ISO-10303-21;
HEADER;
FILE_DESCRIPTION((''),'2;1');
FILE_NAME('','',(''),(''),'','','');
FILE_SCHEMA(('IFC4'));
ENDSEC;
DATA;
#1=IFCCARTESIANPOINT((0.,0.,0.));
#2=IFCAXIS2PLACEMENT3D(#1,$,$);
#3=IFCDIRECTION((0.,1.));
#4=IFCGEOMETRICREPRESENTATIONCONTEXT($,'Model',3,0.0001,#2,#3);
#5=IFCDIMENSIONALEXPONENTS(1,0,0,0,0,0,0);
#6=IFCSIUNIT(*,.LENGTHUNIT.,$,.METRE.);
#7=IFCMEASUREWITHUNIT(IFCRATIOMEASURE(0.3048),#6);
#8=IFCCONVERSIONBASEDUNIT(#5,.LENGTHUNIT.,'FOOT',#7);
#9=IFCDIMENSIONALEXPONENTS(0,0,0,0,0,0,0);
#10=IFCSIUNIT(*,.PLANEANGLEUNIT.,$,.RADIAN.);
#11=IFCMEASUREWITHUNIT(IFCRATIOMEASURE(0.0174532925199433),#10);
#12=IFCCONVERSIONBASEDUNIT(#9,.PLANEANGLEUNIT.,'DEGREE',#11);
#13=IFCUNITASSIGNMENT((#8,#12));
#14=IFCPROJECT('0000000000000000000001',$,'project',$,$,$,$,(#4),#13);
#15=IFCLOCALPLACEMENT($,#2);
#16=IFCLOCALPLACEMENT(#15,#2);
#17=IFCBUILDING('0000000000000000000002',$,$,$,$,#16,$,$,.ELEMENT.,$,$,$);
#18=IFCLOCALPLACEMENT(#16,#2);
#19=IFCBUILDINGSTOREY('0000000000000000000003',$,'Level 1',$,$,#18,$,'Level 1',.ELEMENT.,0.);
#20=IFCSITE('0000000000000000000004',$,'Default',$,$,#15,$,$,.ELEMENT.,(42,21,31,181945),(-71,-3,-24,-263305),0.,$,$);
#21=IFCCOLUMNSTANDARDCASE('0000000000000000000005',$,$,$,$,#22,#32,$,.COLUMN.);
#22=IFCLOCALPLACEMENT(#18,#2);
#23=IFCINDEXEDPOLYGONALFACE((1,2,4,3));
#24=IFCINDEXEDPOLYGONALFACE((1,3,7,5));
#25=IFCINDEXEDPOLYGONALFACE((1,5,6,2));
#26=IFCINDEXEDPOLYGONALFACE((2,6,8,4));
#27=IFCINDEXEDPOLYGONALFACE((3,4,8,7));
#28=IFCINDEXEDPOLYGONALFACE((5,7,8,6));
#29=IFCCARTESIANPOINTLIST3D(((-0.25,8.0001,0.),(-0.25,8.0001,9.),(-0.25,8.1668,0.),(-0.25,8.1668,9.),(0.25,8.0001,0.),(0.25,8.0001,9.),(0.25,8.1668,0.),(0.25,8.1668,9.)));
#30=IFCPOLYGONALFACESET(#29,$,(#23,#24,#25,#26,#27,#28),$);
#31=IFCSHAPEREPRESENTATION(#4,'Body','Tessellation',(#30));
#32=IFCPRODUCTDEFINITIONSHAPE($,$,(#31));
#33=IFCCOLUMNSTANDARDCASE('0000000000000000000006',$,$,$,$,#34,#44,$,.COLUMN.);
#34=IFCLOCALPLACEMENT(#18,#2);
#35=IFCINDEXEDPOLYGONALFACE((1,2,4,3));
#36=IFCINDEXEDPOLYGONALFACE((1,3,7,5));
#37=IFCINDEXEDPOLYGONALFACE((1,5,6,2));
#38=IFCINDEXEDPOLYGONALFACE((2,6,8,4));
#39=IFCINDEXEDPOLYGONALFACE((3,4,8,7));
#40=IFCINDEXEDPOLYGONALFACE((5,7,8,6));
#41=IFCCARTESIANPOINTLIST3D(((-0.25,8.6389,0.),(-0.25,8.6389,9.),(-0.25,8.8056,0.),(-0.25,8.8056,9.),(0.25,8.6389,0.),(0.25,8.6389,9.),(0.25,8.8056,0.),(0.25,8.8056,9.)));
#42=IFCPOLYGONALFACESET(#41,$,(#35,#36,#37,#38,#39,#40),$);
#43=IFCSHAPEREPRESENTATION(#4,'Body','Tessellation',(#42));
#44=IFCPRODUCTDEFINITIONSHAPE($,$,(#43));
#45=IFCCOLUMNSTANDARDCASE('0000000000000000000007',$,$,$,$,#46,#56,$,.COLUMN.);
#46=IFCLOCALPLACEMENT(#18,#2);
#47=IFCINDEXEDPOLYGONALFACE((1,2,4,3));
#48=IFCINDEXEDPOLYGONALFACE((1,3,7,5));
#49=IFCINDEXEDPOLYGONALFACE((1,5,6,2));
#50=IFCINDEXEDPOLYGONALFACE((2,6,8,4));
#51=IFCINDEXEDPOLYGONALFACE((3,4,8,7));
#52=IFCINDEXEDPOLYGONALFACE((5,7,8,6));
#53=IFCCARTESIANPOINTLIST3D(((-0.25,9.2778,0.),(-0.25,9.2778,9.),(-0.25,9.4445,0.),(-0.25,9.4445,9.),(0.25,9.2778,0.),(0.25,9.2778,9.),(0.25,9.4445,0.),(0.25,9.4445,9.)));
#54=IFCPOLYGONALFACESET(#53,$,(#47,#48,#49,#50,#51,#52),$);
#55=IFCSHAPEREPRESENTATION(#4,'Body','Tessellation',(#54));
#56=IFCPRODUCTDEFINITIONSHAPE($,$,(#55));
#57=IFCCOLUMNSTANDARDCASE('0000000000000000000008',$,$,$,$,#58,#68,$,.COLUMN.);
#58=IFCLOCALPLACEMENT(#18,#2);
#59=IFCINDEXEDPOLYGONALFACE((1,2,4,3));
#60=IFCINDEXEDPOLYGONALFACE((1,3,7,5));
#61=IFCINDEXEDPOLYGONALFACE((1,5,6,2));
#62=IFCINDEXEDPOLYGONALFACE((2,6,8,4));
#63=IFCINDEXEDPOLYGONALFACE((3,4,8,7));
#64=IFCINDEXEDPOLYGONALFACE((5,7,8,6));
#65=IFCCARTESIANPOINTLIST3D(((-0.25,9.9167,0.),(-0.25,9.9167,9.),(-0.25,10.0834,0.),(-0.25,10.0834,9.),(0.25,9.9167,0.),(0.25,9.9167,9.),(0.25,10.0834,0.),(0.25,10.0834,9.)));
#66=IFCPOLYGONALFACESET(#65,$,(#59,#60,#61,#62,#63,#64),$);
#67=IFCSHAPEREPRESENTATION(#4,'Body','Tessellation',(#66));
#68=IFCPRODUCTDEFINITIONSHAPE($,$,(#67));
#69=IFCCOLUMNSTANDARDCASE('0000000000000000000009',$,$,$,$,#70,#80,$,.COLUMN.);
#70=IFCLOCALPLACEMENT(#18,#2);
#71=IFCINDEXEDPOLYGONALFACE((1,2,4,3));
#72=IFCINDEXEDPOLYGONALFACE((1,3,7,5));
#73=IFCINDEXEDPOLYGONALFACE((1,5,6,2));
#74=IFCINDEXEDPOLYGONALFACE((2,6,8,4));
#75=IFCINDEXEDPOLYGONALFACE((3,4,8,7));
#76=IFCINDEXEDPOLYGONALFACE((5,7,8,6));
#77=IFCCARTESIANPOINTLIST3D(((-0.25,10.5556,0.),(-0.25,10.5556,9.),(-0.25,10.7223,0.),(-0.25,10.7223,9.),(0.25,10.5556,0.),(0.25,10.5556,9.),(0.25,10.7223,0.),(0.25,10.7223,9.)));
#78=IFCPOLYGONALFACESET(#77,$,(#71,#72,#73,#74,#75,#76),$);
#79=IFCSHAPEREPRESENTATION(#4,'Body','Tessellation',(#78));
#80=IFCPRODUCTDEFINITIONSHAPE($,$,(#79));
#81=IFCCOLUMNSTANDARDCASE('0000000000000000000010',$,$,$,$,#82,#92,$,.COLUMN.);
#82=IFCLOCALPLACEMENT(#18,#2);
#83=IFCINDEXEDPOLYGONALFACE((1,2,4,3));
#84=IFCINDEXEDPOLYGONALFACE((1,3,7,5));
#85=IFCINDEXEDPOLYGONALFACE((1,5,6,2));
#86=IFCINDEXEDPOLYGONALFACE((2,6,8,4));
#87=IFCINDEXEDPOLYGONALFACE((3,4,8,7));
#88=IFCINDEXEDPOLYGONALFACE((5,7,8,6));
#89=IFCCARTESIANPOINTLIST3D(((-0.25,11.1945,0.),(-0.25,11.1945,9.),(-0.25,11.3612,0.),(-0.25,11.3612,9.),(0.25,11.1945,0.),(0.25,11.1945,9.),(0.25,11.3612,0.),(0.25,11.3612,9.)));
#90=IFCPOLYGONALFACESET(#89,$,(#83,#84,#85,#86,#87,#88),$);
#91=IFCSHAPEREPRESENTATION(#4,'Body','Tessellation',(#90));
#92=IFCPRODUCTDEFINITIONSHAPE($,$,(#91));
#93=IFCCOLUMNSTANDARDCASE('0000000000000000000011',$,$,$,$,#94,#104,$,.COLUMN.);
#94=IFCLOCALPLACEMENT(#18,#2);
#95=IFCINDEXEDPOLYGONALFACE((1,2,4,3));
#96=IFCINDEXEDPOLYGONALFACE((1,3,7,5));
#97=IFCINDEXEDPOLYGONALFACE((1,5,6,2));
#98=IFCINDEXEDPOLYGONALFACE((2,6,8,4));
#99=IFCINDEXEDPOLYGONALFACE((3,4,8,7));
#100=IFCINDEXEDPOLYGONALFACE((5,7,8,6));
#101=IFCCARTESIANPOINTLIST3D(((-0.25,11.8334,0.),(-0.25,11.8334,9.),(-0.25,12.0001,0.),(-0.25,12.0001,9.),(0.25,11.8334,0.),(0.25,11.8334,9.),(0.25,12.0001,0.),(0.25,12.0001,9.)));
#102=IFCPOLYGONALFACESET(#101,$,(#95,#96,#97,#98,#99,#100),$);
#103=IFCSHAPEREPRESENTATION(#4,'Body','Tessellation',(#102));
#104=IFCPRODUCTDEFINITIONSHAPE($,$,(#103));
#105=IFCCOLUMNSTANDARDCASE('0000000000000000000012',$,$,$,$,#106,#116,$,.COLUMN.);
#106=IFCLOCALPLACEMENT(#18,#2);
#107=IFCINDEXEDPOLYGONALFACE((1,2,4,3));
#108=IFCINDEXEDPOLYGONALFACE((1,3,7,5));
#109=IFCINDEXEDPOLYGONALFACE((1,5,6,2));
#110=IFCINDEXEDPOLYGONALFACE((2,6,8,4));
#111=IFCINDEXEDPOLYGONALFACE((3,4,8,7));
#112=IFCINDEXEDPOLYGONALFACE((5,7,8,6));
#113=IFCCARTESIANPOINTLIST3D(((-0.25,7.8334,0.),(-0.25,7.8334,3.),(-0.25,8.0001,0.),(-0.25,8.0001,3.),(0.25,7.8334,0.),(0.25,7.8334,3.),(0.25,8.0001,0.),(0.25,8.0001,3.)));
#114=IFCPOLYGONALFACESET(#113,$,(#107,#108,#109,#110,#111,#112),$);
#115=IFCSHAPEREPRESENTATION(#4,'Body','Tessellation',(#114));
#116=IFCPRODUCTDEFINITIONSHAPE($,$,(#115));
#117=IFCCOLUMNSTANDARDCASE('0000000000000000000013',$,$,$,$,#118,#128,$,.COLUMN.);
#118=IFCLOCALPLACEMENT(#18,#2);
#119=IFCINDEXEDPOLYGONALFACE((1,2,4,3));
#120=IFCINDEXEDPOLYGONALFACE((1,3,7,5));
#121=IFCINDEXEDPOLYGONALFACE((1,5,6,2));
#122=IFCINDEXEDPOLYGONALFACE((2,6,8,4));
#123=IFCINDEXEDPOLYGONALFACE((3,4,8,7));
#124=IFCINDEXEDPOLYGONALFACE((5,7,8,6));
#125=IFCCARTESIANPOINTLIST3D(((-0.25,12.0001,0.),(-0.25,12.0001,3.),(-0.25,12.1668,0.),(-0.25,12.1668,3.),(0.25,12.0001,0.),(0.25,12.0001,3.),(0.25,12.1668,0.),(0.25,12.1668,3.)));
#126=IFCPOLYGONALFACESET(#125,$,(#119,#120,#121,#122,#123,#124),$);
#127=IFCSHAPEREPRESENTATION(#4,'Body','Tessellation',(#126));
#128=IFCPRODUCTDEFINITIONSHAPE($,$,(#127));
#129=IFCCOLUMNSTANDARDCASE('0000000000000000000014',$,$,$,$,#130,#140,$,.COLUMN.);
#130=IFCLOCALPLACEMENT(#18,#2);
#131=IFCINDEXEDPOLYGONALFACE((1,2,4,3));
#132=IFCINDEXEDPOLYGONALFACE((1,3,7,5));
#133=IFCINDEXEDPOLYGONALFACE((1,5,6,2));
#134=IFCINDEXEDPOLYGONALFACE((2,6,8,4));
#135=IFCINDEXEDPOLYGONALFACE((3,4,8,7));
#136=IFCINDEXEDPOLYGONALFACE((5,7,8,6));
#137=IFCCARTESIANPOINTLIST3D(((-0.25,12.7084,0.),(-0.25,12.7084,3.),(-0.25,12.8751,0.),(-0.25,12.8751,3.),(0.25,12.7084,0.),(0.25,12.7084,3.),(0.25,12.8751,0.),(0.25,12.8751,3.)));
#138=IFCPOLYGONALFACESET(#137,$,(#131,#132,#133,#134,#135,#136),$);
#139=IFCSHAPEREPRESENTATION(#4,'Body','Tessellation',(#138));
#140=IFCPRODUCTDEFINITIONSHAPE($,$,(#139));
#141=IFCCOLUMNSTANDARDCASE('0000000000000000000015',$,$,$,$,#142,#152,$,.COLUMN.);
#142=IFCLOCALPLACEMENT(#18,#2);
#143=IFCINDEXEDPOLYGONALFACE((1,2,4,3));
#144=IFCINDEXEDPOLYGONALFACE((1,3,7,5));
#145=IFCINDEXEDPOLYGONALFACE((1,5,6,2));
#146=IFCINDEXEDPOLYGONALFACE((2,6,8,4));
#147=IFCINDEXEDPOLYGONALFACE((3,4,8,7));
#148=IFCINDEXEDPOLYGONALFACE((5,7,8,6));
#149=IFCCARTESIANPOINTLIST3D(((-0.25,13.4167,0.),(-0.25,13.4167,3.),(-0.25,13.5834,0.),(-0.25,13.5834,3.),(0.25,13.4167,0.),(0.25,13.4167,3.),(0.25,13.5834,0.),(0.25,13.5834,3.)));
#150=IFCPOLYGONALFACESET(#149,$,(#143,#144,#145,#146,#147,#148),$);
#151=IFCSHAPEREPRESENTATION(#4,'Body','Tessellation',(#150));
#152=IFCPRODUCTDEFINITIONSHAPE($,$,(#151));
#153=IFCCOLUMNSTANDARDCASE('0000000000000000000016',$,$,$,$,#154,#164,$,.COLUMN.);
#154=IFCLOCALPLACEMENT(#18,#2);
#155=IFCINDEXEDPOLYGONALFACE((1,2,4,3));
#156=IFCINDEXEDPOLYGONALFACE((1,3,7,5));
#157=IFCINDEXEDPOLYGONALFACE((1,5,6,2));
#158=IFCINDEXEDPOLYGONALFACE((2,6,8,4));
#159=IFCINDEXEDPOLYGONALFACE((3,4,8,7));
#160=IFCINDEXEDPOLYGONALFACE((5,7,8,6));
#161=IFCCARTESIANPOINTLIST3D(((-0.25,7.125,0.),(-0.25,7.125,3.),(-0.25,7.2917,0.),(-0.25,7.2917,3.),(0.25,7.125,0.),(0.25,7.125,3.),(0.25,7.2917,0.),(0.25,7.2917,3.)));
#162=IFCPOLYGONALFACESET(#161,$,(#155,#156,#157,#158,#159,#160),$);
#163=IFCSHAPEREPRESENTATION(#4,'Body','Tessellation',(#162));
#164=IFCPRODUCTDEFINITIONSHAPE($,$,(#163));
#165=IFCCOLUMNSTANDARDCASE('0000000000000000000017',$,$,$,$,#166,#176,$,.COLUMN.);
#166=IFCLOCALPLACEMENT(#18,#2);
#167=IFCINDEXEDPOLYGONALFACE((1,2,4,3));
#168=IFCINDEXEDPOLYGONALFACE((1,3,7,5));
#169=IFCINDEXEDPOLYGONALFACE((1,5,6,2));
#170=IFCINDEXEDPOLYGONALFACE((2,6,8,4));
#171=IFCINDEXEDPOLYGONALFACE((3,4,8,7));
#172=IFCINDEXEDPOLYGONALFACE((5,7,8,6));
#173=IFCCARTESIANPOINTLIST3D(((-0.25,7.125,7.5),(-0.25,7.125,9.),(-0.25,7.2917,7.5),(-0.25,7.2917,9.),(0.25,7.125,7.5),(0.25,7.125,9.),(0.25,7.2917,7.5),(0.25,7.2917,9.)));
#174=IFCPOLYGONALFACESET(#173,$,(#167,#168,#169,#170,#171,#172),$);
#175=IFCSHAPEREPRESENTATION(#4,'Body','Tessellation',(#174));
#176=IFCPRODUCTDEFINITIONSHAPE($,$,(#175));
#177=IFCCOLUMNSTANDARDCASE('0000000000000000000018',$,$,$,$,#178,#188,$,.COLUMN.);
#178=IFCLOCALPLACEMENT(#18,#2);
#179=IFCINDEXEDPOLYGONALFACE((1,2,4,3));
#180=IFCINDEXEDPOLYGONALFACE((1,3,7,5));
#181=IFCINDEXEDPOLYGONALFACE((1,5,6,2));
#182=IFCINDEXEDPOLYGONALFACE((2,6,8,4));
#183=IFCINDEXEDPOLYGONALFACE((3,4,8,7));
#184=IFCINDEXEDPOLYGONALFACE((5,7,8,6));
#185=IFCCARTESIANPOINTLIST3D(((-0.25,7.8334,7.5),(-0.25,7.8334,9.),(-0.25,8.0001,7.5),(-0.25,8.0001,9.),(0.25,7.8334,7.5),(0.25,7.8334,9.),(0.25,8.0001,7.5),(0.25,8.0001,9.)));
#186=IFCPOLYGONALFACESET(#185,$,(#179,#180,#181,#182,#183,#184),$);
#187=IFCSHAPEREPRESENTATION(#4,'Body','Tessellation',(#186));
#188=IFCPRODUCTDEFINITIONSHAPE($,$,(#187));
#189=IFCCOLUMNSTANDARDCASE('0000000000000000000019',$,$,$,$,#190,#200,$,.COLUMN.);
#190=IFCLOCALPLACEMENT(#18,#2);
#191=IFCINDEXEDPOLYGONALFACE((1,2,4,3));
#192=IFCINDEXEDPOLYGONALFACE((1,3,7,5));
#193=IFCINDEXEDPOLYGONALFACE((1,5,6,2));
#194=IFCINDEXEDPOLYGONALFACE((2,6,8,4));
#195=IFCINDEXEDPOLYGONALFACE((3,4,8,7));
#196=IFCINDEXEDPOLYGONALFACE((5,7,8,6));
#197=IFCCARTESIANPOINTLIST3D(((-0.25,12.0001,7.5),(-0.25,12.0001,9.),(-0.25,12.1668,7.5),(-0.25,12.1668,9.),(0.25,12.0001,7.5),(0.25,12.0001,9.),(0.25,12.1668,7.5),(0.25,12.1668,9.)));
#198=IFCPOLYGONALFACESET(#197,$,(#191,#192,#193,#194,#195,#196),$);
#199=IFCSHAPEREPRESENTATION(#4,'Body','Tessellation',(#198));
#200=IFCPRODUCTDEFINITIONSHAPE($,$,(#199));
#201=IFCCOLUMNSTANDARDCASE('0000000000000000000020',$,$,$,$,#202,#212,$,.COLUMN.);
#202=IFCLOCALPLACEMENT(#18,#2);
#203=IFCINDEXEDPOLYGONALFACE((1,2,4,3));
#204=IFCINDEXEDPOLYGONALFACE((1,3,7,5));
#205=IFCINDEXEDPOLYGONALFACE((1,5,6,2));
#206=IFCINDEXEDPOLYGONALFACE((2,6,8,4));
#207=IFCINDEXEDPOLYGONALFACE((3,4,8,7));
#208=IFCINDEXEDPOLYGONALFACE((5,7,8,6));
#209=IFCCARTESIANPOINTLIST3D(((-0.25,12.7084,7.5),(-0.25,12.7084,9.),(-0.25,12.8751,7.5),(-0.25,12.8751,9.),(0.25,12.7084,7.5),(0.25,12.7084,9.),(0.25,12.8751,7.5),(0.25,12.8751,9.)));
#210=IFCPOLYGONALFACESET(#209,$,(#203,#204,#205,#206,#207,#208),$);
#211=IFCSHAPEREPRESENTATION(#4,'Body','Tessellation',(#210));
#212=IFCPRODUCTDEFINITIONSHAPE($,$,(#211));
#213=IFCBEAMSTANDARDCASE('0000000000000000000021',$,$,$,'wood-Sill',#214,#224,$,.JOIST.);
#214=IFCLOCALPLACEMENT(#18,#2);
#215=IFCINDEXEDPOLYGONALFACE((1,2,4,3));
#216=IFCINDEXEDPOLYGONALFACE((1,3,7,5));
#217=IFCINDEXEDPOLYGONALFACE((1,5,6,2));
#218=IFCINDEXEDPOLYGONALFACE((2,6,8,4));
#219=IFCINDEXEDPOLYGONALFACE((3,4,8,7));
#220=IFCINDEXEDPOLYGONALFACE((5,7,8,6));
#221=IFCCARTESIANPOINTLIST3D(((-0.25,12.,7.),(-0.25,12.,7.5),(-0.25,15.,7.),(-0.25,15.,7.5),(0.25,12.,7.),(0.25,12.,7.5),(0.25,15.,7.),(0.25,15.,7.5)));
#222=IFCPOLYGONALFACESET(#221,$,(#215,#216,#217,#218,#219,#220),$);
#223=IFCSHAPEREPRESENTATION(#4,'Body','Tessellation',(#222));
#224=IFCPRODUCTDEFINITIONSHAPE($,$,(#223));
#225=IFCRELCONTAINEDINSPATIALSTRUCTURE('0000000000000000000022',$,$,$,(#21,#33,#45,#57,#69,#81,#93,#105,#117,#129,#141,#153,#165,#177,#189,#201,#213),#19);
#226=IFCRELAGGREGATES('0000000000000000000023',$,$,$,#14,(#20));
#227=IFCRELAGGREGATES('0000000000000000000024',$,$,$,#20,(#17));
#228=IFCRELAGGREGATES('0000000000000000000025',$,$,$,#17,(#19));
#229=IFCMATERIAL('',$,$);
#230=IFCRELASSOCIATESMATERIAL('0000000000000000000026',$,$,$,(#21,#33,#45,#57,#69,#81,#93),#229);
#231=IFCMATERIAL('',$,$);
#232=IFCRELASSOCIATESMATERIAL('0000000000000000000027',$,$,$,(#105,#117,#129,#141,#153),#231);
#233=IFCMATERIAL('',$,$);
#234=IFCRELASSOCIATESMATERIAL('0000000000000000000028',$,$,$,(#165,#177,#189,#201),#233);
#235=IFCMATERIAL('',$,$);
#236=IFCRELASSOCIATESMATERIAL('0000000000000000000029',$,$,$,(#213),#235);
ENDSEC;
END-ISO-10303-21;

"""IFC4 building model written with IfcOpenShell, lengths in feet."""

from ifc_helpers import new_model, entity, si_unit, converted_unit, direction, frame, origin, place, context, project, spatial, rectangle, extrude, material, element, save


model = new_model("IFC4")

# Units and contexts
model_context = context("Model", 3, precision=0.0001, world=origin(), true_north=direction((0.0, 1.0)))
ifc_project = project(units=[converted_unit("LENGTHUNIT", "FOOT", entity("IfcRatioMeasure", 0.3048), si_unit("LENGTHUNIT", "METRE"), dimensions=[1, 0, 0, 0, 0, 0, 0]), converted_unit("PLANEANGLEUNIT", "DEGREE", entity("IfcRatioMeasure", 0.0174532925199433), si_unit("PLANEANGLEUNIT", "RADIAN"), dimensions=[0, 0, 0, 0, 0, 0, 0])], contexts=[model_context])

# Site, building, storey
site_placement = place(None, origin())
site = spatial("IfcSite", under=ifc_project, at=site_placement, Name="Default", CompositionType="ELEMENT", RefLatitude=(42, 21, 31, 181945), RefLongitude=(-71, -3, -24, -263305), RefElevation=0.0)
building_placement = place(site_placement, origin())
building = spatial("IfcBuilding", under=site, at=building_placement, CompositionType="ELEMENT")
storey_placement = place(building_placement, origin())
storey = spatial("IfcBuildingStorey", under=building, at=storey_placement, Name="Level 1", LongName="Level 1", CompositionType="ELEMENT", Elevation=0.0)

# Columns
ifc_material_1 = material(Name="")
placement = place(storey_placement, frame((0.0, -0.25, 0.0), z_axis=(0.0, 0.0, 1.0), x_axis=(0.0, 1.0, 0.0)))
for number, where, z_axis, x_axis in (
    (1, (8.3334, 0.0, 0.0), (0.0, 0.0, 1.0), (1.0, 0.0, 0.0)),
    (2, (8.9722, 0.0, 0.0), (0.0, 0.0, 1.0), (1.0, 0.0, 0.0)),
    (3, (9.6111, 0.0, 0.0), (0.0, 0.0, 1.0), (1.0, 0.0, 0.0)),
    (4, (10.25, 0.0, 0.0), (0.0, 0.0, 1.0), (1.0, 0.0, 0.0)),
    (5, (10.8889, 0.0, 0.0), (0.0, 0.0, 1.0), (1.0, 0.0, 0.0)),
    (6, (11.5278, 0.0, 0.0), (0.0, 0.0, 1.0), (1.0, 0.0, 0.0)),
    (7, (12.1667, 0.0, 0.0), (0.0, 0.0, 1.0), (1.0, 0.0, 0.0)),
):
    element("IfcColumnStandardCase", number, at=place(placement, frame(where, z_axis=z_axis, x_axis=x_axis)), inside=storey, material=ifc_material_1, PredefinedType="COLUMN", context=model_context, shape_type="SweptSolid", body=[
        extrude(rectangle(XDim=0.1667, YDim=0.5), origin(), (0.0, 0.0, 1.0), 9.0),
    ])
ifc_material_2 = material(Name="")
for number, where, z_axis, x_axis in (
    (8, (8.1667, 0.0, 0.0), (0.0, 0.0, 1.0), (1.0, 0.0, 0.0)),
    (9, (12.3334, 0.0, 0.0), (0.0, 0.0, 1.0), (1.0, 0.0, 0.0)),
    (10, (13.0417, 0.0, 0.0), (0.0, 0.0, 1.0), (1.0, 0.0, 0.0)),
    (11, (13.75, 0.0, 0.0), (0.0, 0.0, 1.0), (1.0, 0.0, 0.0)),
    (12, (7.4583, 0.0, 0.0), (0.0, 0.0, 1.0), (1.0, 0.0, 0.0)),
):
    element("IfcColumnStandardCase", number, at=place(placement, frame(where, z_axis=z_axis, x_axis=x_axis)), inside=storey, material=ifc_material_2, PredefinedType="COLUMN", context=model_context, shape_type="SweptSolid", body=[
        extrude(rectangle(XDim=0.1667, YDim=0.5), origin(), (0.0, 0.0, 1.0), 3.0),
    ])
ifc_material_3 = material(Name="")
for number, where, z_axis, x_axis in (
    (13, (7.4583, 0.0, 7.5), (0.0, 0.0, 1.0), (1.0, 0.0, 0.0)),
    (14, (8.1667, 0.0, 7.5), (0.0, 0.0, 1.0), (1.0, 0.0, 0.0)),
    (15, (12.3334, 0.0, 7.5), (0.0, 0.0, 1.0), (1.0, 0.0, 0.0)),
    (16, (13.0417, 0.0, 7.5), (0.0, 0.0, 1.0), (1.0, 0.0, 0.0)),
):
    element("IfcColumnStandardCase", number, at=place(placement, frame(where, z_axis=z_axis, x_axis=x_axis)), inside=storey, material=ifc_material_3, PredefinedType="COLUMN", context=model_context, shape_type="SweptSolid", body=[
        extrude(rectangle(XDim=0.1667, YDim=0.5), origin(), (0.0, 0.0, 1.0), 1.5),
    ])

# Beam
ifc_material_4 = material(Name="")
for number, where, z_axis, x_axis in (
    (17, (13.75, 0.0, 7.0), (0.0, 0.0, 1.0), (1.0, 0.0, 0.0)),
):
    element("IfcBeamStandardCase", number, at=place(placement, frame(where, z_axis=z_axis, x_axis=x_axis)), inside=storey, material=ifc_material_4, ObjectType="wood-Sill", PredefinedType="JOIST", context=model_context, shape_type="SweptSolid", body=[
        extrude(rectangle(XDim=3.0, YDim=0.5), origin(), (0.0, 0.0, 1.0), 0.5),
    ])

save(model, "model.ifc")
